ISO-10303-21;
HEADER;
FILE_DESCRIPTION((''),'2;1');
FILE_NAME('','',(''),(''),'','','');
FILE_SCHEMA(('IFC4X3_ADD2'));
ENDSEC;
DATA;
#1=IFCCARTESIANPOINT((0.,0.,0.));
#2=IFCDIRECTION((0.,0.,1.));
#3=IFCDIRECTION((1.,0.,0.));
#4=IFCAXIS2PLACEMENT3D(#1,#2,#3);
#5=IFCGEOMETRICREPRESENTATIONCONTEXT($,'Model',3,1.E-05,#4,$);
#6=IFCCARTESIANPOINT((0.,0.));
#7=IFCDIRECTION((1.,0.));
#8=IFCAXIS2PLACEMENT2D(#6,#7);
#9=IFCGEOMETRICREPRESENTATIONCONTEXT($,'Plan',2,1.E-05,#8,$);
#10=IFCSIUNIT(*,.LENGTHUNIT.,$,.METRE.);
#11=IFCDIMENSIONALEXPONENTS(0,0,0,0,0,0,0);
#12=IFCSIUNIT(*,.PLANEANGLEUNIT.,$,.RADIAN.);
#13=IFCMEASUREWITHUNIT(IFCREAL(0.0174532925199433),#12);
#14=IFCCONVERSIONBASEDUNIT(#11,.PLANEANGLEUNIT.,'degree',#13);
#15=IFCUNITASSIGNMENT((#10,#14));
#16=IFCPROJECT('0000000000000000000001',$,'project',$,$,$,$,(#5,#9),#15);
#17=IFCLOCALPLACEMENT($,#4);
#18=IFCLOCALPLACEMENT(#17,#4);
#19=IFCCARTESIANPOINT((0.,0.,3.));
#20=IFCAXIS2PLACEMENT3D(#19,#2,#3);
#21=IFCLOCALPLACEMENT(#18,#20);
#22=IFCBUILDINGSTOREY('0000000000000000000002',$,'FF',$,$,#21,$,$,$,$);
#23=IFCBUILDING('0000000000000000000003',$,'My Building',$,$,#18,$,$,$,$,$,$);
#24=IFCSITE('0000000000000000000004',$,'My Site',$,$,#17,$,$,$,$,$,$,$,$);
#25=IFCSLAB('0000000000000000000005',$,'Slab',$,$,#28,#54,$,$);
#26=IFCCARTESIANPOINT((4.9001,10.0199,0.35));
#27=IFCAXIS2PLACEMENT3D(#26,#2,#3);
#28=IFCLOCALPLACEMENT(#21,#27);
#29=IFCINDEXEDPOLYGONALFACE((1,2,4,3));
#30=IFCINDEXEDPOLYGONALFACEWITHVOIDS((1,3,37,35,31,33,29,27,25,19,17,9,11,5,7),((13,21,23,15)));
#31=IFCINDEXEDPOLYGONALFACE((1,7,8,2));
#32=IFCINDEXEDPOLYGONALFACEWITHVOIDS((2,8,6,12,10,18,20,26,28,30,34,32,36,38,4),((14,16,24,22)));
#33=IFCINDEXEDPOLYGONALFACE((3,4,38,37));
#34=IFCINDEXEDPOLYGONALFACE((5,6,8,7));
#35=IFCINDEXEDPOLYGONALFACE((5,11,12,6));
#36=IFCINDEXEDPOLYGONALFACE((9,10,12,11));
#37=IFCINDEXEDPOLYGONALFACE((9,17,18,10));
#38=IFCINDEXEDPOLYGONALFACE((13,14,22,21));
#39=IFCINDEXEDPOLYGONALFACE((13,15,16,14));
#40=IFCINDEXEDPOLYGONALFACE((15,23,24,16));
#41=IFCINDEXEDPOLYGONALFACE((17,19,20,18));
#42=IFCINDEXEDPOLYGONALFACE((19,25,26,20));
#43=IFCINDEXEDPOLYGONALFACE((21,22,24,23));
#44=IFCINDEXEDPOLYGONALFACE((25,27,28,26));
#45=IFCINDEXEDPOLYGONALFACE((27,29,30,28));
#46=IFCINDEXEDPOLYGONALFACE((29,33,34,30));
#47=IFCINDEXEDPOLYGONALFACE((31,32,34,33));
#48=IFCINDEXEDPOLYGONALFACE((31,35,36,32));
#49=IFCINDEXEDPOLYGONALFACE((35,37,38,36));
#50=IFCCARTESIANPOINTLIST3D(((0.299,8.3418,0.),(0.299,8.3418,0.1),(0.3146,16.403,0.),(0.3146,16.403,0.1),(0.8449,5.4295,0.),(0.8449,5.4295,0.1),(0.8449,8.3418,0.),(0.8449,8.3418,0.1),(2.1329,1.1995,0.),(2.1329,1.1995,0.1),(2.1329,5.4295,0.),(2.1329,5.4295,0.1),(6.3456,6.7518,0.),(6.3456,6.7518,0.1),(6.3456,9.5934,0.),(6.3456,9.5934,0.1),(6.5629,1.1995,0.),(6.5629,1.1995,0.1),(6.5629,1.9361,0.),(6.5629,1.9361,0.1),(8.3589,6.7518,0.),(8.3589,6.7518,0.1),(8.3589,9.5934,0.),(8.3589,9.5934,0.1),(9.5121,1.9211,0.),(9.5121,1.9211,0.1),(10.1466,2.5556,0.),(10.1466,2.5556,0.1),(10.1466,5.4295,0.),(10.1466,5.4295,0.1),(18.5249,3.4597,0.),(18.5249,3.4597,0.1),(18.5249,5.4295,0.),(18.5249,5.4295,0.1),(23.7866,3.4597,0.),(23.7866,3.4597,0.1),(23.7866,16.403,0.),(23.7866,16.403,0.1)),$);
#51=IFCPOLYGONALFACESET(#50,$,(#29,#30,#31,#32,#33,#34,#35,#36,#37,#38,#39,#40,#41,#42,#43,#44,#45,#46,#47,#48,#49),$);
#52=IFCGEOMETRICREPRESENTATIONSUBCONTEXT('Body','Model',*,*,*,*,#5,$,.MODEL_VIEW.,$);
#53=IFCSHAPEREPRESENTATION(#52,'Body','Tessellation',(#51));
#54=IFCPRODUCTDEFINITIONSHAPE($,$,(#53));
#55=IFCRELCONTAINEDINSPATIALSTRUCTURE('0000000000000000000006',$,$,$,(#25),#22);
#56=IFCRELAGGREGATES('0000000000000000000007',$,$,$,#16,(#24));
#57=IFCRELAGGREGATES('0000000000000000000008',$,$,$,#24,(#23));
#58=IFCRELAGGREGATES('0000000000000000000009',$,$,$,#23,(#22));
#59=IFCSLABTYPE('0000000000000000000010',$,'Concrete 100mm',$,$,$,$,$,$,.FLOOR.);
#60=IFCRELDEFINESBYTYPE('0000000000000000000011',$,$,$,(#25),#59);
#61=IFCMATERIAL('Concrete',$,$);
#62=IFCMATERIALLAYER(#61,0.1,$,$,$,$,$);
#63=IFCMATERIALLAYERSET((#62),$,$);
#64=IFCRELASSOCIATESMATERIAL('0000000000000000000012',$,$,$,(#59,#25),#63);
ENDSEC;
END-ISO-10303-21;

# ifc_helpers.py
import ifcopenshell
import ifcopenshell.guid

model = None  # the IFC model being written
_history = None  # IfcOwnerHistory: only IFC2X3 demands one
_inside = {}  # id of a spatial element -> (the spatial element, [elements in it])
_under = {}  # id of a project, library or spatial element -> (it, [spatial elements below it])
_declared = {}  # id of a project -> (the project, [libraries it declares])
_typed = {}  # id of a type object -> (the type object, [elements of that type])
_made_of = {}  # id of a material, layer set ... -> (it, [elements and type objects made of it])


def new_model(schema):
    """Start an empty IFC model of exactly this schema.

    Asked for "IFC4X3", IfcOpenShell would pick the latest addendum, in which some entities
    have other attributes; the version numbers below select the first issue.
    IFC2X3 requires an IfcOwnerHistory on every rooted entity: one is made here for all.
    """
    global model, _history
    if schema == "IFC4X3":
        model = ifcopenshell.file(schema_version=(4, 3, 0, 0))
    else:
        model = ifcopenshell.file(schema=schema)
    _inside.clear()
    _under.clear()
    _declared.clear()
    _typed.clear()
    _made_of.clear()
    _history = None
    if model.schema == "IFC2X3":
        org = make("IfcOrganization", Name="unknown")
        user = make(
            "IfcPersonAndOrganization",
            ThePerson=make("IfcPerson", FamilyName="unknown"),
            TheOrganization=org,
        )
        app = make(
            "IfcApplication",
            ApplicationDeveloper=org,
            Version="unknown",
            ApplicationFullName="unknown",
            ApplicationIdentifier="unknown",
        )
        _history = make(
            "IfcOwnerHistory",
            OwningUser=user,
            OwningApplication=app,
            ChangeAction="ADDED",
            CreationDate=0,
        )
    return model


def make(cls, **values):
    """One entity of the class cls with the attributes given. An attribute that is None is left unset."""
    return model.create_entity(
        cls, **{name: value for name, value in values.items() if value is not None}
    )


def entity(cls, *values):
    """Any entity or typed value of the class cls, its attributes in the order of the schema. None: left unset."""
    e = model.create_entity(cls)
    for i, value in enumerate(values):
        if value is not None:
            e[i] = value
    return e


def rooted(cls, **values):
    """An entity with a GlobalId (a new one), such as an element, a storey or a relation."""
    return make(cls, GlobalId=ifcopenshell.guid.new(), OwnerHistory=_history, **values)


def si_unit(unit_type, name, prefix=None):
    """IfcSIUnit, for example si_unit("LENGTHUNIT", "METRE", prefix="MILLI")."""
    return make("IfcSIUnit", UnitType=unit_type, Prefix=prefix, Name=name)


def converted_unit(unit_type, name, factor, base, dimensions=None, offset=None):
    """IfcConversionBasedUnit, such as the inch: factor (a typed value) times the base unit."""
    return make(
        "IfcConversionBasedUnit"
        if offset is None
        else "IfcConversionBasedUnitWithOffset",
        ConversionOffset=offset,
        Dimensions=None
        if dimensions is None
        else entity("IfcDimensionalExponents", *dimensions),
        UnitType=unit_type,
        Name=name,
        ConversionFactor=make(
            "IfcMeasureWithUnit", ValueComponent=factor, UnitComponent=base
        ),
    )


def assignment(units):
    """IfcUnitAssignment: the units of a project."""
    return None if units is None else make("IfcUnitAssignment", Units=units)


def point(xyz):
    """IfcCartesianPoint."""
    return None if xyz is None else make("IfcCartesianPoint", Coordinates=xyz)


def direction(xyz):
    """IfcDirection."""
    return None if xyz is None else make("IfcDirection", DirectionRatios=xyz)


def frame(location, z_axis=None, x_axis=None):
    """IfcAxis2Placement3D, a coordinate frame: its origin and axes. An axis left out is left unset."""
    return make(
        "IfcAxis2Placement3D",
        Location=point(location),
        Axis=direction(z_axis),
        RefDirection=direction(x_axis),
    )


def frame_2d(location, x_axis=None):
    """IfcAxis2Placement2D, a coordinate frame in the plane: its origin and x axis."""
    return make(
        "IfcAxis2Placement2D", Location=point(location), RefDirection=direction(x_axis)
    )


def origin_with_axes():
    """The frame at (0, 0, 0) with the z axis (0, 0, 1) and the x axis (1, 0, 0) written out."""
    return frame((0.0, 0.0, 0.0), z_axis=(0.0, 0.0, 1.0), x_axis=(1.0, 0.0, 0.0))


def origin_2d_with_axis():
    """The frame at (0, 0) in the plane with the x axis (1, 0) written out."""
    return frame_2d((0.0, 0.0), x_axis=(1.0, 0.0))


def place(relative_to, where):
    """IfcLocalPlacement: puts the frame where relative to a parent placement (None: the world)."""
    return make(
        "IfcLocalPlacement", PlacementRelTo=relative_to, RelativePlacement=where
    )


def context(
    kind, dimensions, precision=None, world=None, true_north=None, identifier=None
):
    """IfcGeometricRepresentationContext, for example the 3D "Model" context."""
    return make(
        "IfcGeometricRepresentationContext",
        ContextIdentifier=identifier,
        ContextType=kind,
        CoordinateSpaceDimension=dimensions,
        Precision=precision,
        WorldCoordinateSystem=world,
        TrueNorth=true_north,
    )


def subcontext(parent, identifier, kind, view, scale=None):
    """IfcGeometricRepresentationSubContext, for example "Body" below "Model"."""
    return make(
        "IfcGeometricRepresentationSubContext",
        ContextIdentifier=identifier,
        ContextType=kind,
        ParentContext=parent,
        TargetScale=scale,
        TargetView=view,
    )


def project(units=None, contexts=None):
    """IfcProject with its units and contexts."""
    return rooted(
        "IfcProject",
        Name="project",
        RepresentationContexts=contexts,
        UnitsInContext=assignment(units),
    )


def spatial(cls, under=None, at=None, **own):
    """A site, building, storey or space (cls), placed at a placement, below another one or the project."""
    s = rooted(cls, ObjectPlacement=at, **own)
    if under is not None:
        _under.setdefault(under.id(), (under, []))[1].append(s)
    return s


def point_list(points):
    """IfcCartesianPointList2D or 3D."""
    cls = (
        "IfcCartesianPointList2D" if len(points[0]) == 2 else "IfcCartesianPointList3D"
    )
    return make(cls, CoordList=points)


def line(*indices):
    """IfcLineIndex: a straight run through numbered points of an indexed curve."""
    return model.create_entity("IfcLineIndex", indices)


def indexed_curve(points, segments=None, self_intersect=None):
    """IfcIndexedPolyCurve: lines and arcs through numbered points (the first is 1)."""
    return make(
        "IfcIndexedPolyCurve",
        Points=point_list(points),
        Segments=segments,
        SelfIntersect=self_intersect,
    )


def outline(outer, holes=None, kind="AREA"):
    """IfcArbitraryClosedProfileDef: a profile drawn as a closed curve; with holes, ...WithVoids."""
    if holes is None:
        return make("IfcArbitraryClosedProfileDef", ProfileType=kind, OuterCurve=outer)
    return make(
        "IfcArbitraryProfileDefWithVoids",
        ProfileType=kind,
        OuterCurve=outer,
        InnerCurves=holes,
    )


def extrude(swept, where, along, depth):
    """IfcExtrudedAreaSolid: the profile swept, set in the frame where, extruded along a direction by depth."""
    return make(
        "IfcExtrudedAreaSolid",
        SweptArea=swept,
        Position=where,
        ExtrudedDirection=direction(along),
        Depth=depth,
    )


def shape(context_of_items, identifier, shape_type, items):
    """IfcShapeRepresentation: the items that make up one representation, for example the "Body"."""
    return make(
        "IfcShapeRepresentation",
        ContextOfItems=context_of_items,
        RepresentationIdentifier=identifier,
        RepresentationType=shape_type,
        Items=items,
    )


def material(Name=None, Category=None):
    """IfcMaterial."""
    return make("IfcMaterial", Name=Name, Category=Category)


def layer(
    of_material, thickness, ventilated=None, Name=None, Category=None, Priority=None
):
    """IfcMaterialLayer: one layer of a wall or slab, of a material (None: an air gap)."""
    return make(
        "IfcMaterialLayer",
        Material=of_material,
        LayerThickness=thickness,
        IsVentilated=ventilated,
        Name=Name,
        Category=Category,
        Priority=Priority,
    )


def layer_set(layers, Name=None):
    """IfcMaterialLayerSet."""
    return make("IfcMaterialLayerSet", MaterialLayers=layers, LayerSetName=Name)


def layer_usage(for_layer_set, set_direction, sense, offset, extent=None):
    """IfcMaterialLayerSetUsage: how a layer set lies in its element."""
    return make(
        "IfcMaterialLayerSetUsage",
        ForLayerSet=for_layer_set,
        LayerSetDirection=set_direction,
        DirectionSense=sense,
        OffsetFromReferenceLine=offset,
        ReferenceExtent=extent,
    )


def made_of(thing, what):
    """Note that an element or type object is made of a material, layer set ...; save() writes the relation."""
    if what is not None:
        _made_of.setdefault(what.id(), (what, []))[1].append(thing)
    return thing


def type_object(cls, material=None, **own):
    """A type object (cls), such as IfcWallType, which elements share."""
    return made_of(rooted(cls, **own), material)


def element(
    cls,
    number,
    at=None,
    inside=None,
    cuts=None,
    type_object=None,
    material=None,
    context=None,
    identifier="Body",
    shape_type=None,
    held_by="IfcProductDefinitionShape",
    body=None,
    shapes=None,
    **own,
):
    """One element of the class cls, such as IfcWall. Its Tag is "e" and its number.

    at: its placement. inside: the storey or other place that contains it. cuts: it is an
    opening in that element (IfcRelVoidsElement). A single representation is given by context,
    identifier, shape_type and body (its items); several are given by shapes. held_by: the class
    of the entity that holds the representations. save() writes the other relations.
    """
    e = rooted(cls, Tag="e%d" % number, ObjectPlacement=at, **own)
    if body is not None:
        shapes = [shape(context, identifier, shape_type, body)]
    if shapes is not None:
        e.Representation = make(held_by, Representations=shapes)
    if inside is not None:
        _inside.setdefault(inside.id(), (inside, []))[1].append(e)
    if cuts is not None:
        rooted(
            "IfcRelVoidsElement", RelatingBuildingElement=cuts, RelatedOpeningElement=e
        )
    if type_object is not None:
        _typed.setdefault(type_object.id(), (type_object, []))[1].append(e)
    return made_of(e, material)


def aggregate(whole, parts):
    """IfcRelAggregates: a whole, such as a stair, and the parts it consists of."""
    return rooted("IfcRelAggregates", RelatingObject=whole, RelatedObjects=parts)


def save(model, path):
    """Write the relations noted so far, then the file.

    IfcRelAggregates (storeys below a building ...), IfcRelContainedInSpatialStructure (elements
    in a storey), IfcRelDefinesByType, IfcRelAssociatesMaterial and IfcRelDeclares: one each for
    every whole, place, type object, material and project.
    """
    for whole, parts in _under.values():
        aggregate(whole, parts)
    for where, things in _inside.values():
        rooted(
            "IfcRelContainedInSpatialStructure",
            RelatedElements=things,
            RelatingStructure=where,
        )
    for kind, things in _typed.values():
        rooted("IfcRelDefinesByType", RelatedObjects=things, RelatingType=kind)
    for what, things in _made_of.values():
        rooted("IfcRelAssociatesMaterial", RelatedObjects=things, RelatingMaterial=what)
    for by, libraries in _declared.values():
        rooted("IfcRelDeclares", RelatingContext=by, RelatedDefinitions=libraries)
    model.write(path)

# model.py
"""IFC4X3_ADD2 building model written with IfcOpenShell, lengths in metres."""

from ifc_helpers import new_model, entity, si_unit, converted_unit, frame, origin_with_axes, origin_2d_with_axis, place, context, subcontext, project, spatial, line, indexed_curve, outline, extrude, material, layer, layer_set, layer_usage, type_object, element, save


model = new_model("IFC4X3_ADD2")

# Units and contexts
model_context = context("Model", 3, precision=1e-05, world=origin_with_axes())
plan_context = context("Plan", 2, precision=1e-05, world=origin_2d_with_axis())
body_context = subcontext(model_context, "Body", "Model", "MODEL_VIEW")
ifc_project = project(units=[si_unit("LENGTHUNIT", "METRE"), converted_unit("PLANEANGLEUNIT", "degree", entity("IfcReal", 0.0174532925199433), si_unit("PLANEANGLEUNIT", "RADIAN"), dimensions=[0, 0, 0, 0, 0, 0, 0])], contexts=[model_context, plan_context])

# Site, building, storey
site_placement = place(None, origin_with_axes())
site = spatial("IfcSite", under=ifc_project, at=site_placement, Name="My Site")
building_placement = place(site_placement, origin_with_axes())
building = spatial("IfcBuilding", under=site, at=building_placement, Name="My Building")
storey_placement = place(building_placement, frame((0.0, 0.0, 3.0), z_axis=(0.0, 0.0, 1.0), x_axis=(1.0, 0.0, 0.0)))
storey = spatial("IfcBuildingStorey", under=building, at=storey_placement, Name="FF")

# Shared definitions
ifc_material = material(Name="Concrete")

# Slab
ifc_layer = layer(ifc_material, 0.1)
ifc_layer_set = layer_set([ifc_layer])
ifc_layer_usage = layer_usage(ifc_layer_set, "AXIS3", "POSITIVE", 0.0)
slab_type = type_object("IfcSlabType", Name="Concrete 100mm", PredefinedType="FLOOR", material=ifc_layer_set)
slab_placement = place(storey_placement, frame((4.9001, 10.0199, 0.35), z_axis=(0.0, 0.0, 1.0), x_axis=(1.0, 0.0, 0.0)))
element("IfcSlab", 1, at=slab_placement, inside=storey, type_object=slab_type, material=ifc_layer_usage, Name="Slab", context=body_context, shape_type="SweptSolid", body=[
    extrude(outline(indexed_curve([(23.7866, 16.403), (23.7866, 3.4597), (18.5249, 3.4597), (18.5249, 5.4295), (10.1466, 5.4295), (10.1466, 2.5556), (9.5121, 1.9211), (6.5629, 1.9361), (6.5629, 1.1995), (2.1329, 1.1995), (2.1329, 5.4295), (0.8449, 5.4295), (0.8449, 8.3418), (0.299, 8.3418), (0.3146, 16.403), (8.3589, 9.5934), (8.3589, 6.7518), (6.3456, 6.7518), (6.3456, 9.5934)], segments=[line(1, 15), line(15, 14), line(14, 13), line(13, 12), line(12, 11), line(11, 10), line(10, 9), line(9, 8), line(8, 7), line(7, 6), line(6, 5), line(5, 4), line(4, 3), line(3, 2), line(2, 1)], self_intersect=False), holes=[indexed_curve([(23.7866, 16.403), (23.7866, 3.4597), (18.5249, 3.4597), (18.5249, 5.4295), (10.1466, 5.4295), (10.1466, 2.5556), (9.5121, 1.9211), (6.5629, 1.9361), (6.5629, 1.1995), (2.1329, 1.1995), (2.1329, 5.4295), (0.8449, 5.4295), (0.8449, 8.3418), (0.299, 8.3418), (0.3146, 16.403), (8.3589, 9.5934), (8.3589, 6.7518), (6.3456, 6.7518), (6.3456, 9.5934)], segments=[line(19, 18), line(18, 17), line(17, 16), line(16, 19)], self_intersect=False)]), None, (0.0, 0.0, 1.0), 0.1),
])

save(model, "model.ifc")
